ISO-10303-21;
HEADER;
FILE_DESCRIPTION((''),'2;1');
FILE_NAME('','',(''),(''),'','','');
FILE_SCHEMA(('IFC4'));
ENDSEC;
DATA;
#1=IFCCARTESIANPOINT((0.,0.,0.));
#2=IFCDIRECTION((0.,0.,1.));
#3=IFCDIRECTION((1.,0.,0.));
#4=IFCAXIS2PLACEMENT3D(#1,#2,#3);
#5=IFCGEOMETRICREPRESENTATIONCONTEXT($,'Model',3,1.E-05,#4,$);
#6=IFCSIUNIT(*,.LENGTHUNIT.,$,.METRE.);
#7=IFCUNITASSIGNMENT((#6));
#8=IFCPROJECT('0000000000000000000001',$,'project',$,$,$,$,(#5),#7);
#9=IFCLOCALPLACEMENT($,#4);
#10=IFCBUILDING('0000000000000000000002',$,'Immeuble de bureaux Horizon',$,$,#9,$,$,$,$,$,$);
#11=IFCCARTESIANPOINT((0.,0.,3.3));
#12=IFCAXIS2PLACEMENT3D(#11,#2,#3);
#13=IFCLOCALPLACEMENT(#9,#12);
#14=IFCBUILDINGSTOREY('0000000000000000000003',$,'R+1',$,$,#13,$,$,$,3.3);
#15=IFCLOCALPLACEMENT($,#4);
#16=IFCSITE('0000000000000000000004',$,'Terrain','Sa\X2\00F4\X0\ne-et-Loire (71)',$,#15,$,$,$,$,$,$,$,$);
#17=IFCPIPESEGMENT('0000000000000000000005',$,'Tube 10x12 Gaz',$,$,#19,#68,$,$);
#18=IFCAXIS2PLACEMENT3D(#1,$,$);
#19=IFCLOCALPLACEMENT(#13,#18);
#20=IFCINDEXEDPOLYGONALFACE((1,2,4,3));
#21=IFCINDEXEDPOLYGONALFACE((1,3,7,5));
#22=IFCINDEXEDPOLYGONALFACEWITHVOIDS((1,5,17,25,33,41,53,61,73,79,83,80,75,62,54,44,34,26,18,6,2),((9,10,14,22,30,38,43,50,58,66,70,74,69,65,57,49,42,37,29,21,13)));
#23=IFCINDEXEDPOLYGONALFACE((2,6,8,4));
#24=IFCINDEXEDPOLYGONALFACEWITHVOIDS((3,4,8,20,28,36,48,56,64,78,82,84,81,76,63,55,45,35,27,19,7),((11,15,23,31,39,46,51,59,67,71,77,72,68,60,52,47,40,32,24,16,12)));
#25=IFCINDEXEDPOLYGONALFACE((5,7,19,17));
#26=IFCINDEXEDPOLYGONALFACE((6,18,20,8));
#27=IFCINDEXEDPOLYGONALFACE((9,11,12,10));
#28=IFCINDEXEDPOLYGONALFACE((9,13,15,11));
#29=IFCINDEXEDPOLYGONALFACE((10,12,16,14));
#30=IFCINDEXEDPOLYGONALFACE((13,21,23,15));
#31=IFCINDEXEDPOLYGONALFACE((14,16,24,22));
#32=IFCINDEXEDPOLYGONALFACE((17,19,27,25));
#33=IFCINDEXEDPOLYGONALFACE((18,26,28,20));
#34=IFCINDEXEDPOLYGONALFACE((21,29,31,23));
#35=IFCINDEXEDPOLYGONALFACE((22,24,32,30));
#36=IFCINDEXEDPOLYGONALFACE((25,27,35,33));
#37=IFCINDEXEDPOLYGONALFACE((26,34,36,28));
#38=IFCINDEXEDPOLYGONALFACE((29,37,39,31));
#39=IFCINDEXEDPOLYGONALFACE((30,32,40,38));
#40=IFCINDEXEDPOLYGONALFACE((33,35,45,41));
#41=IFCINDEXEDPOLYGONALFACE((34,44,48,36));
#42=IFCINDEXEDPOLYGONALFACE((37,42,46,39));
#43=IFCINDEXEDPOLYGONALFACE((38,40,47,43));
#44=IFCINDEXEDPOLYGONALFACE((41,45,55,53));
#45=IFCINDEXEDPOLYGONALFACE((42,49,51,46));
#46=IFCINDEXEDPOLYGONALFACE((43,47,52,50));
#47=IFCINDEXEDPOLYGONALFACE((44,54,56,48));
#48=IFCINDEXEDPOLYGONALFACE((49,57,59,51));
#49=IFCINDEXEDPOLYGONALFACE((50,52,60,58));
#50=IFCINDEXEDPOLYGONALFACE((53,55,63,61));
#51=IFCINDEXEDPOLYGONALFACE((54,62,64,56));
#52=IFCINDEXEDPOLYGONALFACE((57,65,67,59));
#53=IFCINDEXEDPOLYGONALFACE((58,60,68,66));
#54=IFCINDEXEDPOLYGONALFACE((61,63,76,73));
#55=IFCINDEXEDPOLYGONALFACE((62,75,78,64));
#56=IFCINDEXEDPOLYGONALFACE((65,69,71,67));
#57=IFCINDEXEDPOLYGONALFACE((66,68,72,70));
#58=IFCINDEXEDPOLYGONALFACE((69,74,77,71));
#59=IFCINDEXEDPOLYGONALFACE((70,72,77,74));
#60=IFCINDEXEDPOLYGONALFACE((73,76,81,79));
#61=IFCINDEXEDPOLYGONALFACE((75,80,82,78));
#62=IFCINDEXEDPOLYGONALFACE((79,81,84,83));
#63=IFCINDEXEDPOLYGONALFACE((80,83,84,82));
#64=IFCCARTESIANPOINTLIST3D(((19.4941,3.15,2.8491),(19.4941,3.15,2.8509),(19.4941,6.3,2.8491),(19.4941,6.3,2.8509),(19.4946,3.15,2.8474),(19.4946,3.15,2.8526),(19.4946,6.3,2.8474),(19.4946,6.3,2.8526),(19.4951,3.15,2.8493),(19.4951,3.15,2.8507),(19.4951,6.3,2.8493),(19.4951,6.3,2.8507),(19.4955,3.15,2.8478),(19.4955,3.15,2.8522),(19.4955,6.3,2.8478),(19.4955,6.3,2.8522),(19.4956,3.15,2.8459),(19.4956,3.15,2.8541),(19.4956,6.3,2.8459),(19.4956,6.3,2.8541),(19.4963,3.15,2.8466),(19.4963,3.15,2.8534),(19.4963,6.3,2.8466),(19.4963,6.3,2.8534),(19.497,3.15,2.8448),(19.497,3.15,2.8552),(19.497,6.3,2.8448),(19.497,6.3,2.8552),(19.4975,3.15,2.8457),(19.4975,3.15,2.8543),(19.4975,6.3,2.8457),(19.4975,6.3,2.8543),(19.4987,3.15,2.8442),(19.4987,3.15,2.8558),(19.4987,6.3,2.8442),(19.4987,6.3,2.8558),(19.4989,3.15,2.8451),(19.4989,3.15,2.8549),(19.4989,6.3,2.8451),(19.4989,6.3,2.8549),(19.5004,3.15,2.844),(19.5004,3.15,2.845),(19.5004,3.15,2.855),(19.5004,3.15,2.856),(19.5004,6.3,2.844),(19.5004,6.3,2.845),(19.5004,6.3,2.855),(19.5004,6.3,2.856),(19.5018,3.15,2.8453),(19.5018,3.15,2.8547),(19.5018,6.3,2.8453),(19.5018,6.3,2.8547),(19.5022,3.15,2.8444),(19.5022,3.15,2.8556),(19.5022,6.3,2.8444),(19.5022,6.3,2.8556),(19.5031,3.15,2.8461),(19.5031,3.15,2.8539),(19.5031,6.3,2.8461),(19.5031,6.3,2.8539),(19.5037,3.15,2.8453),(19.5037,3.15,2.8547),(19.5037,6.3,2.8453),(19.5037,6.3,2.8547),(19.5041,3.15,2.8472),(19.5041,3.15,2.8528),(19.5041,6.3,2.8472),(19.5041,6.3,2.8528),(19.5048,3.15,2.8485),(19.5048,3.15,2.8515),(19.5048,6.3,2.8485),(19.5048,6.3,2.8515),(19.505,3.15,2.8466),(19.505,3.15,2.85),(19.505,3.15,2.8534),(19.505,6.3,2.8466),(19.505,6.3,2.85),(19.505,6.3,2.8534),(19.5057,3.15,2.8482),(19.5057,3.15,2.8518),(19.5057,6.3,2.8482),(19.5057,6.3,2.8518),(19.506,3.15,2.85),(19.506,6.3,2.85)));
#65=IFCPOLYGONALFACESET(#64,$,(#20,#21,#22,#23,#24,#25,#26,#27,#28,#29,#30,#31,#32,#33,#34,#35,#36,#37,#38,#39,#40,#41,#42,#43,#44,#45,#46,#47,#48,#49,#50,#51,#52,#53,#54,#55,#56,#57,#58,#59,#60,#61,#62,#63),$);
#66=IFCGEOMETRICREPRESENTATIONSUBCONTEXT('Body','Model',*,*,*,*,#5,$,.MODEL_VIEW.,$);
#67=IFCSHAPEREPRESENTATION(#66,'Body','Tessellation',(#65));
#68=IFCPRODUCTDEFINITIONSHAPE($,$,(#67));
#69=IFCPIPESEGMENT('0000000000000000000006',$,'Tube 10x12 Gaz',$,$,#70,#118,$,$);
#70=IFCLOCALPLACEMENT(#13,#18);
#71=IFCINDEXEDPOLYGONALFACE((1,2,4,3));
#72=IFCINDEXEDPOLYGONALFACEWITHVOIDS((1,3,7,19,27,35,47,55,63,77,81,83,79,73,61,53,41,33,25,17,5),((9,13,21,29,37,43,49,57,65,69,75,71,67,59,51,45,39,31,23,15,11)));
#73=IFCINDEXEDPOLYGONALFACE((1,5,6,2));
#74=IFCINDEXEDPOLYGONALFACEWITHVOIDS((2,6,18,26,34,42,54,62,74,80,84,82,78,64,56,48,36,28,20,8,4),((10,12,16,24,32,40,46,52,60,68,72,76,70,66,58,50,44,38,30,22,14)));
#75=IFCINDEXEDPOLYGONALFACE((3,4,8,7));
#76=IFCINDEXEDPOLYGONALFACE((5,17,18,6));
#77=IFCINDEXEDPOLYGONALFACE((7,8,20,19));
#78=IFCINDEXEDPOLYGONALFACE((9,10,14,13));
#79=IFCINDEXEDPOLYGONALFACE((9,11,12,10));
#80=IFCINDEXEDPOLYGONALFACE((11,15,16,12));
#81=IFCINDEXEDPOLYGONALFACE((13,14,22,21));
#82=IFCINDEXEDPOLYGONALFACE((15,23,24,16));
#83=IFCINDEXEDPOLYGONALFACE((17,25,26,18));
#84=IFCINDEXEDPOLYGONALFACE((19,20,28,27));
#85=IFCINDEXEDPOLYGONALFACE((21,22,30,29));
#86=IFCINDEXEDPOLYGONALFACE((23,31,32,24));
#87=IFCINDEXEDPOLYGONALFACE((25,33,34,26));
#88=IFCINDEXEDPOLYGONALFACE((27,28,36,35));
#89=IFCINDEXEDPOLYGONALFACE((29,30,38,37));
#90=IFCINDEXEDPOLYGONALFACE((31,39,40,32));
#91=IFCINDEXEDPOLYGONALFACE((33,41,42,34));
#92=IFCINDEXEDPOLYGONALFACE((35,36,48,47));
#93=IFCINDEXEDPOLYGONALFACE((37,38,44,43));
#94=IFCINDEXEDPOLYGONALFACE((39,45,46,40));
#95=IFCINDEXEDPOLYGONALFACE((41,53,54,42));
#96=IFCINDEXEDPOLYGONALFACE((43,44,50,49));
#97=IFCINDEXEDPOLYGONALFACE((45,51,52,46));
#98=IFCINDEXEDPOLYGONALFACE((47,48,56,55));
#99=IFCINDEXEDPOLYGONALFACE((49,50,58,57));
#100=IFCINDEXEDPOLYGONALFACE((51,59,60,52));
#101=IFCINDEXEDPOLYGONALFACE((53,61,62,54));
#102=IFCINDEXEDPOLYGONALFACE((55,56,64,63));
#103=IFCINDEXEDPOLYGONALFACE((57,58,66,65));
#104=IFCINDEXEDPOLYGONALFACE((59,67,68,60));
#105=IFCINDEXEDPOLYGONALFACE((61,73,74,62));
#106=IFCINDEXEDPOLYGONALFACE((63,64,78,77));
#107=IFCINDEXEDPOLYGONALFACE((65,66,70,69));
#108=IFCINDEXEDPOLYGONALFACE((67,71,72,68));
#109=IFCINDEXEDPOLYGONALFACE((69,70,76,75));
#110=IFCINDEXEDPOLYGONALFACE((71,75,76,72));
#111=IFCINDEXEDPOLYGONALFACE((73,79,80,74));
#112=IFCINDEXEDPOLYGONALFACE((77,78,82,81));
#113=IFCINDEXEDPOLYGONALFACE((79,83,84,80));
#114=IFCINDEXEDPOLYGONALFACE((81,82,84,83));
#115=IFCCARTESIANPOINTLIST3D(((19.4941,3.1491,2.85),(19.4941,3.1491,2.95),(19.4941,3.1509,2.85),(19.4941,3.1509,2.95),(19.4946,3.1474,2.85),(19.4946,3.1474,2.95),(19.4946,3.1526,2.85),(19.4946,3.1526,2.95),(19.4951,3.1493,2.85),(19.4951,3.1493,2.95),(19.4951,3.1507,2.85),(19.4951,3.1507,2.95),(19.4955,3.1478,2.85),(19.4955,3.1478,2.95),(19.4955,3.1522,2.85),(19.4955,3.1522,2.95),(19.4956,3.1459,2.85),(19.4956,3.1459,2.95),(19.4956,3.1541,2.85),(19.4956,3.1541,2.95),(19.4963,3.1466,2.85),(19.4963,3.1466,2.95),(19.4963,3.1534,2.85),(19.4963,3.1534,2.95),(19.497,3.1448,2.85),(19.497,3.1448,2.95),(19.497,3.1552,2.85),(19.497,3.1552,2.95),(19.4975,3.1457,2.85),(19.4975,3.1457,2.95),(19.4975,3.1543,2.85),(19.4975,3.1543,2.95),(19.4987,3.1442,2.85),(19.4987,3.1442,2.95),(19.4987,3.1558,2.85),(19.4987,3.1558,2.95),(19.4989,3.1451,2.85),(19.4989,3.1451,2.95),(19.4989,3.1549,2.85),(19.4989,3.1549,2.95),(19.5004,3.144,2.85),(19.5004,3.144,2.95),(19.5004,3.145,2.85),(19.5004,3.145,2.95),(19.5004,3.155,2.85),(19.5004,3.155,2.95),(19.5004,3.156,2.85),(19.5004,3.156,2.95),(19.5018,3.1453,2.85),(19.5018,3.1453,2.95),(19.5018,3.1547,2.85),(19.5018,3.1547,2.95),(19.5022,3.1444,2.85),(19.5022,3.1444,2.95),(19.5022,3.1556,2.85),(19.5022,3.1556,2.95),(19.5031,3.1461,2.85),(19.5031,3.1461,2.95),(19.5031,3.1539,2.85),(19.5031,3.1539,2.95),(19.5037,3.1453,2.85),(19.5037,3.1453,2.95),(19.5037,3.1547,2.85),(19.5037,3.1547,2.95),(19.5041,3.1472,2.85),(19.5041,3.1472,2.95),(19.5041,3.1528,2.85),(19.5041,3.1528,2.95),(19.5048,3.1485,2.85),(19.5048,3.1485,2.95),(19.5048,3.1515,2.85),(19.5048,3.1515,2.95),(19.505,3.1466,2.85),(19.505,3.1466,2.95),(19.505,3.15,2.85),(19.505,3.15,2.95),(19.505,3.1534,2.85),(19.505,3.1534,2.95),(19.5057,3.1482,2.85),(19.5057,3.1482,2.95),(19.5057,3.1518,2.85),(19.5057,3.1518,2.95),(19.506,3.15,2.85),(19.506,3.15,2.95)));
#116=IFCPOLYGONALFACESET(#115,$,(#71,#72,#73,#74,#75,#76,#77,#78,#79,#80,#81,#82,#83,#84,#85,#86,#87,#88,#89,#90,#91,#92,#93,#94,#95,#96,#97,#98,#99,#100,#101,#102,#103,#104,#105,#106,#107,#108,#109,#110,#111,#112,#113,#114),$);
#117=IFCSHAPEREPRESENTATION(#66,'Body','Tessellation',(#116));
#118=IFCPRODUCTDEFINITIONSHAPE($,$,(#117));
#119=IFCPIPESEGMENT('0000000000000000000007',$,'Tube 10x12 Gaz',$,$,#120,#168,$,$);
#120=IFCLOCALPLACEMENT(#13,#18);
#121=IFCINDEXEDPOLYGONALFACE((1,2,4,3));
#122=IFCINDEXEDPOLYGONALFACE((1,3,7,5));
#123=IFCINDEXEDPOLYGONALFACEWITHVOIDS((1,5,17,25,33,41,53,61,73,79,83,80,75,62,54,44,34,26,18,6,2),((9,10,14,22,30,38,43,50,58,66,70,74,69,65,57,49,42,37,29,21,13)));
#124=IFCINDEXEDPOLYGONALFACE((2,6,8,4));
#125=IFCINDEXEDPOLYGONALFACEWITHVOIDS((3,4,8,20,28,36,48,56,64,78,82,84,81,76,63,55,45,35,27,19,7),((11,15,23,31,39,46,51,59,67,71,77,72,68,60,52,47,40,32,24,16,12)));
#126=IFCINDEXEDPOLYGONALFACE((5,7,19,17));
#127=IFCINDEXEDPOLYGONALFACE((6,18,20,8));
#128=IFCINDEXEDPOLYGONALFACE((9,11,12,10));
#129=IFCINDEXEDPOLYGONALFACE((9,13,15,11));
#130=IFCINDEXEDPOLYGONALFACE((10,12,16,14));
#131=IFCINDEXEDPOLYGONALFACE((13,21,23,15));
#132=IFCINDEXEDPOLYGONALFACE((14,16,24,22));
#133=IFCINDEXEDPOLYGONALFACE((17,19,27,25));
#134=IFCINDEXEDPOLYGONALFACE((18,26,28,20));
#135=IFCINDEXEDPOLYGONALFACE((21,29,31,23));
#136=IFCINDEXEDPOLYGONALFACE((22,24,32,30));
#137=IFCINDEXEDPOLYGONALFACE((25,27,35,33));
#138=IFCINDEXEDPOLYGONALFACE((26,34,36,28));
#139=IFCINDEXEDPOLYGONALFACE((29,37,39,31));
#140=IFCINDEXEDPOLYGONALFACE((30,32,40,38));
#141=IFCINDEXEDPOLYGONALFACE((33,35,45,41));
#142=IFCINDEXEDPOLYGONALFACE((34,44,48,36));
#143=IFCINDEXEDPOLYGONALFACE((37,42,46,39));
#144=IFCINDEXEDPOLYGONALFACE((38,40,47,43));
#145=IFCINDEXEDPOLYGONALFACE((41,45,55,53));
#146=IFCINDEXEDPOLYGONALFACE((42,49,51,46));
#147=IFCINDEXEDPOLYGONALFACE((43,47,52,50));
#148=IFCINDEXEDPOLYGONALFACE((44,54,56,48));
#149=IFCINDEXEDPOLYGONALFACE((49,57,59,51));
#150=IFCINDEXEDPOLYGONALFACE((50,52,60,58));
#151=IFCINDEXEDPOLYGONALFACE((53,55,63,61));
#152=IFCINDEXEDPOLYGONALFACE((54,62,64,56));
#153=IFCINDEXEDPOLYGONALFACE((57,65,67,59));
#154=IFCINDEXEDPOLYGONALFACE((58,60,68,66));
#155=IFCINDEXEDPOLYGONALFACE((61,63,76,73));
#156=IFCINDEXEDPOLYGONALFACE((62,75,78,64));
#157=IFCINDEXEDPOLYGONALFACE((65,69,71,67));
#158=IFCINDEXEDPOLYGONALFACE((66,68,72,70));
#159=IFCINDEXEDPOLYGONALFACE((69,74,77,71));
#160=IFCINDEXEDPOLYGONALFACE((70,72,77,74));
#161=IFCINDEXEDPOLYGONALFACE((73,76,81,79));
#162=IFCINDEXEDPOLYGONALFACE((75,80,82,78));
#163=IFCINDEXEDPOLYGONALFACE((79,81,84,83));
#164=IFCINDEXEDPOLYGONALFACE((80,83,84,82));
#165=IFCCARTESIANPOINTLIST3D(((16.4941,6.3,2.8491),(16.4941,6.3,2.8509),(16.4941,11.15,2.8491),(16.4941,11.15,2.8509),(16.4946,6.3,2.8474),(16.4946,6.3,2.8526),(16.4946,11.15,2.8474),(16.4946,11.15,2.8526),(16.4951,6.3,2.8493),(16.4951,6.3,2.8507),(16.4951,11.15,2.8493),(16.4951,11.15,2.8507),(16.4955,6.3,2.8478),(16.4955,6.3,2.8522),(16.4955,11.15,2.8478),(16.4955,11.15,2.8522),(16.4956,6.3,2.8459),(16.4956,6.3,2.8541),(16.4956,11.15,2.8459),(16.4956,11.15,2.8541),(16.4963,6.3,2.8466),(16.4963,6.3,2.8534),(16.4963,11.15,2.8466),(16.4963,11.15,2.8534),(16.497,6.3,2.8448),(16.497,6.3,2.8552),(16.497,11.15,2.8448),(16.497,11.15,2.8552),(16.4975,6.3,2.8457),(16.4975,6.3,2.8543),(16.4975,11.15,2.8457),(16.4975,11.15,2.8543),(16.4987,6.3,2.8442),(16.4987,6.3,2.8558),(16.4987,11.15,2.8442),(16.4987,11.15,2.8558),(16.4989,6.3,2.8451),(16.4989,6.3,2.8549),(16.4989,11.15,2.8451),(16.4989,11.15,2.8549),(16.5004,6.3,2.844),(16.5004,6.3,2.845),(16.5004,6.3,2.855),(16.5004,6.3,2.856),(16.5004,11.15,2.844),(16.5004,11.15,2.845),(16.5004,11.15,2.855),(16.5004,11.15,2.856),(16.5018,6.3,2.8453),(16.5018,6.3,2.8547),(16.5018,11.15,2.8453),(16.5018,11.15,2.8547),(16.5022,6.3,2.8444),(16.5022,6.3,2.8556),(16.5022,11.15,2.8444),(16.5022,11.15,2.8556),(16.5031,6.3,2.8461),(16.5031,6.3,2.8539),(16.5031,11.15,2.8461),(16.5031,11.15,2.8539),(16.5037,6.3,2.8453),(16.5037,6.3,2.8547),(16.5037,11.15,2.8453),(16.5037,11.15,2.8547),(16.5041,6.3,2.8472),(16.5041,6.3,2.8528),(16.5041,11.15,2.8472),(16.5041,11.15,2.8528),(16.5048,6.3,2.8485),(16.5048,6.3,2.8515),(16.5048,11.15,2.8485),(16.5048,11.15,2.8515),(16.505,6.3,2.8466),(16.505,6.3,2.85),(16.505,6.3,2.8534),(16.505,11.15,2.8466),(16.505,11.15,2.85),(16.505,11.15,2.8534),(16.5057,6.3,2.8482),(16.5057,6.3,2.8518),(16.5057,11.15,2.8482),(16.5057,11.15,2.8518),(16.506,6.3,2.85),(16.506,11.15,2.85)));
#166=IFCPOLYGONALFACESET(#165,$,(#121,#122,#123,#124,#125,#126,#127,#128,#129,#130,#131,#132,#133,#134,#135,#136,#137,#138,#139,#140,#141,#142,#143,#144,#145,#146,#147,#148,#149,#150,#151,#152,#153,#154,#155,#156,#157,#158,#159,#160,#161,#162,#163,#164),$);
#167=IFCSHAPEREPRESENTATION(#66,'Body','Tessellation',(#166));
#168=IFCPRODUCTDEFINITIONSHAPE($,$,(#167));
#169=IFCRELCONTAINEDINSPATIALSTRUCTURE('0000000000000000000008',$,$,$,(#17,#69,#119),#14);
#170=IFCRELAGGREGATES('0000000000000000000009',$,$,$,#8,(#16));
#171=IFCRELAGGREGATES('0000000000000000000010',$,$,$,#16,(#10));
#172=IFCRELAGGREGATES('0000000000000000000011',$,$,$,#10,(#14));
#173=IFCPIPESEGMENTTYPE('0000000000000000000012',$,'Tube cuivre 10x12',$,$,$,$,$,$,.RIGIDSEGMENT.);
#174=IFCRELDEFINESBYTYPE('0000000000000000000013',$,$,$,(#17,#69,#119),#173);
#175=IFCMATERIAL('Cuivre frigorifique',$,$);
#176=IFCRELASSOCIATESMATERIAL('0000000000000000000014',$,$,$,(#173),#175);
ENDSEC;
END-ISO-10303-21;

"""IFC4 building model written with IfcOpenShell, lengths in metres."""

from ifc_helpers import new_model, si_unit, frame, origin_with_axes, place, context, subcontext, project, spatial, hollow_circle, extrude, material, type_object, element, save


model = new_model("IFC4")

# Units and contexts
model_context = context("Model", 3, precision=1e-05, world=origin_with_axes())
body_context = subcontext(model_context, "Body", "Model", "MODEL_VIEW")
ifc_project = project(units=[si_unit("LENGTHUNIT", "METRE")], contexts=[model_context])

# Site, building, storey
site_placement = place(None, origin_with_axes())
site = spatial("IfcSite", under=ifc_project, at=site_placement, Name="Terrain", Description="Saône-et-Loire (71)")
building_placement = place(None, origin_with_axes())
building = spatial("IfcBuilding", under=site, at=building_placement, Name="Immeuble de bureaux Horizon")
storey_placement = place(building_placement, frame((0.0, 0.0, 3.3), z_axis=(0.0, 0.0, 1.0), x_axis=(1.0, 0.0, 0.0)))
storey = spatial("IfcBuildingStorey", under=building, at=storey_placement, Name="R+1", Elevation=3.3)

# Pipe segments
ifc_material_1 = material(Name="Cuivre frigorifique")
pipe_segment_type_1 = type_object("IfcPipeSegmentType", Name="Tube cuivre 10x12", PredefinedType="RIGIDSEGMENT", material=ifc_material_1)
pipe_segment_1_placement = place(storey_placement, frame((19.5, 6.3, 2.85), z_axis=(0.0, -1.0, 0.0), x_axis=(1.0, 0.0, 0.0)))
element("IfcPipeSegment", 1, at=pipe_segment_1_placement, inside=storey, type_object=pipe_segment_type_1, Name="Tube 10x12 Gaz", context=body_context, shape_type="SweptSolid", body=[
    extrude(hollow_circle(Radius=0.006, WallThickness=0.001), origin_with_axes(), (0.0, 0.0, 1.0), 3.15),
])
pipe_segment_2_placement = place(storey_placement, frame((19.5, 3.15, 2.85), z_axis=(0.0, 0.0, 1.0), x_axis=(1.0, 0.0, 0.0)))
element("IfcPipeSegment", 2, at=pipe_segment_2_placement, inside=storey, type_object=pipe_segment_type_1, Name="Tube 10x12 Gaz", context=body_context, shape_type="SweptSolid", body=[
    extrude(hollow_circle(Radius=0.006, WallThickness=0.001), origin_with_axes(), (0.0, 0.0, 1.0), 0.1),
])
for number, where, z_axis, x_axis, name in (
    (3, (16.5, 6.3, 2.85), (0.0, 1.0, 0.0), (1.0, 0.0, 0.0), "Tube 10x12 Gaz"),
):
    element("IfcPipeSegment", number, at=place(storey_placement, frame(where, z_axis=z_axis, x_axis=x_axis)), inside=storey, type_object=pipe_segment_type_1, Name=name, context=body_context, shape_type="SweptSolid", body=[
        extrude(hollow_circle(Radius=0.006, WallThickness=0.001), origin_with_axes(), (0.0, 0.0, 1.0), 4.85),
    ])

save(model, "model.ifc")
